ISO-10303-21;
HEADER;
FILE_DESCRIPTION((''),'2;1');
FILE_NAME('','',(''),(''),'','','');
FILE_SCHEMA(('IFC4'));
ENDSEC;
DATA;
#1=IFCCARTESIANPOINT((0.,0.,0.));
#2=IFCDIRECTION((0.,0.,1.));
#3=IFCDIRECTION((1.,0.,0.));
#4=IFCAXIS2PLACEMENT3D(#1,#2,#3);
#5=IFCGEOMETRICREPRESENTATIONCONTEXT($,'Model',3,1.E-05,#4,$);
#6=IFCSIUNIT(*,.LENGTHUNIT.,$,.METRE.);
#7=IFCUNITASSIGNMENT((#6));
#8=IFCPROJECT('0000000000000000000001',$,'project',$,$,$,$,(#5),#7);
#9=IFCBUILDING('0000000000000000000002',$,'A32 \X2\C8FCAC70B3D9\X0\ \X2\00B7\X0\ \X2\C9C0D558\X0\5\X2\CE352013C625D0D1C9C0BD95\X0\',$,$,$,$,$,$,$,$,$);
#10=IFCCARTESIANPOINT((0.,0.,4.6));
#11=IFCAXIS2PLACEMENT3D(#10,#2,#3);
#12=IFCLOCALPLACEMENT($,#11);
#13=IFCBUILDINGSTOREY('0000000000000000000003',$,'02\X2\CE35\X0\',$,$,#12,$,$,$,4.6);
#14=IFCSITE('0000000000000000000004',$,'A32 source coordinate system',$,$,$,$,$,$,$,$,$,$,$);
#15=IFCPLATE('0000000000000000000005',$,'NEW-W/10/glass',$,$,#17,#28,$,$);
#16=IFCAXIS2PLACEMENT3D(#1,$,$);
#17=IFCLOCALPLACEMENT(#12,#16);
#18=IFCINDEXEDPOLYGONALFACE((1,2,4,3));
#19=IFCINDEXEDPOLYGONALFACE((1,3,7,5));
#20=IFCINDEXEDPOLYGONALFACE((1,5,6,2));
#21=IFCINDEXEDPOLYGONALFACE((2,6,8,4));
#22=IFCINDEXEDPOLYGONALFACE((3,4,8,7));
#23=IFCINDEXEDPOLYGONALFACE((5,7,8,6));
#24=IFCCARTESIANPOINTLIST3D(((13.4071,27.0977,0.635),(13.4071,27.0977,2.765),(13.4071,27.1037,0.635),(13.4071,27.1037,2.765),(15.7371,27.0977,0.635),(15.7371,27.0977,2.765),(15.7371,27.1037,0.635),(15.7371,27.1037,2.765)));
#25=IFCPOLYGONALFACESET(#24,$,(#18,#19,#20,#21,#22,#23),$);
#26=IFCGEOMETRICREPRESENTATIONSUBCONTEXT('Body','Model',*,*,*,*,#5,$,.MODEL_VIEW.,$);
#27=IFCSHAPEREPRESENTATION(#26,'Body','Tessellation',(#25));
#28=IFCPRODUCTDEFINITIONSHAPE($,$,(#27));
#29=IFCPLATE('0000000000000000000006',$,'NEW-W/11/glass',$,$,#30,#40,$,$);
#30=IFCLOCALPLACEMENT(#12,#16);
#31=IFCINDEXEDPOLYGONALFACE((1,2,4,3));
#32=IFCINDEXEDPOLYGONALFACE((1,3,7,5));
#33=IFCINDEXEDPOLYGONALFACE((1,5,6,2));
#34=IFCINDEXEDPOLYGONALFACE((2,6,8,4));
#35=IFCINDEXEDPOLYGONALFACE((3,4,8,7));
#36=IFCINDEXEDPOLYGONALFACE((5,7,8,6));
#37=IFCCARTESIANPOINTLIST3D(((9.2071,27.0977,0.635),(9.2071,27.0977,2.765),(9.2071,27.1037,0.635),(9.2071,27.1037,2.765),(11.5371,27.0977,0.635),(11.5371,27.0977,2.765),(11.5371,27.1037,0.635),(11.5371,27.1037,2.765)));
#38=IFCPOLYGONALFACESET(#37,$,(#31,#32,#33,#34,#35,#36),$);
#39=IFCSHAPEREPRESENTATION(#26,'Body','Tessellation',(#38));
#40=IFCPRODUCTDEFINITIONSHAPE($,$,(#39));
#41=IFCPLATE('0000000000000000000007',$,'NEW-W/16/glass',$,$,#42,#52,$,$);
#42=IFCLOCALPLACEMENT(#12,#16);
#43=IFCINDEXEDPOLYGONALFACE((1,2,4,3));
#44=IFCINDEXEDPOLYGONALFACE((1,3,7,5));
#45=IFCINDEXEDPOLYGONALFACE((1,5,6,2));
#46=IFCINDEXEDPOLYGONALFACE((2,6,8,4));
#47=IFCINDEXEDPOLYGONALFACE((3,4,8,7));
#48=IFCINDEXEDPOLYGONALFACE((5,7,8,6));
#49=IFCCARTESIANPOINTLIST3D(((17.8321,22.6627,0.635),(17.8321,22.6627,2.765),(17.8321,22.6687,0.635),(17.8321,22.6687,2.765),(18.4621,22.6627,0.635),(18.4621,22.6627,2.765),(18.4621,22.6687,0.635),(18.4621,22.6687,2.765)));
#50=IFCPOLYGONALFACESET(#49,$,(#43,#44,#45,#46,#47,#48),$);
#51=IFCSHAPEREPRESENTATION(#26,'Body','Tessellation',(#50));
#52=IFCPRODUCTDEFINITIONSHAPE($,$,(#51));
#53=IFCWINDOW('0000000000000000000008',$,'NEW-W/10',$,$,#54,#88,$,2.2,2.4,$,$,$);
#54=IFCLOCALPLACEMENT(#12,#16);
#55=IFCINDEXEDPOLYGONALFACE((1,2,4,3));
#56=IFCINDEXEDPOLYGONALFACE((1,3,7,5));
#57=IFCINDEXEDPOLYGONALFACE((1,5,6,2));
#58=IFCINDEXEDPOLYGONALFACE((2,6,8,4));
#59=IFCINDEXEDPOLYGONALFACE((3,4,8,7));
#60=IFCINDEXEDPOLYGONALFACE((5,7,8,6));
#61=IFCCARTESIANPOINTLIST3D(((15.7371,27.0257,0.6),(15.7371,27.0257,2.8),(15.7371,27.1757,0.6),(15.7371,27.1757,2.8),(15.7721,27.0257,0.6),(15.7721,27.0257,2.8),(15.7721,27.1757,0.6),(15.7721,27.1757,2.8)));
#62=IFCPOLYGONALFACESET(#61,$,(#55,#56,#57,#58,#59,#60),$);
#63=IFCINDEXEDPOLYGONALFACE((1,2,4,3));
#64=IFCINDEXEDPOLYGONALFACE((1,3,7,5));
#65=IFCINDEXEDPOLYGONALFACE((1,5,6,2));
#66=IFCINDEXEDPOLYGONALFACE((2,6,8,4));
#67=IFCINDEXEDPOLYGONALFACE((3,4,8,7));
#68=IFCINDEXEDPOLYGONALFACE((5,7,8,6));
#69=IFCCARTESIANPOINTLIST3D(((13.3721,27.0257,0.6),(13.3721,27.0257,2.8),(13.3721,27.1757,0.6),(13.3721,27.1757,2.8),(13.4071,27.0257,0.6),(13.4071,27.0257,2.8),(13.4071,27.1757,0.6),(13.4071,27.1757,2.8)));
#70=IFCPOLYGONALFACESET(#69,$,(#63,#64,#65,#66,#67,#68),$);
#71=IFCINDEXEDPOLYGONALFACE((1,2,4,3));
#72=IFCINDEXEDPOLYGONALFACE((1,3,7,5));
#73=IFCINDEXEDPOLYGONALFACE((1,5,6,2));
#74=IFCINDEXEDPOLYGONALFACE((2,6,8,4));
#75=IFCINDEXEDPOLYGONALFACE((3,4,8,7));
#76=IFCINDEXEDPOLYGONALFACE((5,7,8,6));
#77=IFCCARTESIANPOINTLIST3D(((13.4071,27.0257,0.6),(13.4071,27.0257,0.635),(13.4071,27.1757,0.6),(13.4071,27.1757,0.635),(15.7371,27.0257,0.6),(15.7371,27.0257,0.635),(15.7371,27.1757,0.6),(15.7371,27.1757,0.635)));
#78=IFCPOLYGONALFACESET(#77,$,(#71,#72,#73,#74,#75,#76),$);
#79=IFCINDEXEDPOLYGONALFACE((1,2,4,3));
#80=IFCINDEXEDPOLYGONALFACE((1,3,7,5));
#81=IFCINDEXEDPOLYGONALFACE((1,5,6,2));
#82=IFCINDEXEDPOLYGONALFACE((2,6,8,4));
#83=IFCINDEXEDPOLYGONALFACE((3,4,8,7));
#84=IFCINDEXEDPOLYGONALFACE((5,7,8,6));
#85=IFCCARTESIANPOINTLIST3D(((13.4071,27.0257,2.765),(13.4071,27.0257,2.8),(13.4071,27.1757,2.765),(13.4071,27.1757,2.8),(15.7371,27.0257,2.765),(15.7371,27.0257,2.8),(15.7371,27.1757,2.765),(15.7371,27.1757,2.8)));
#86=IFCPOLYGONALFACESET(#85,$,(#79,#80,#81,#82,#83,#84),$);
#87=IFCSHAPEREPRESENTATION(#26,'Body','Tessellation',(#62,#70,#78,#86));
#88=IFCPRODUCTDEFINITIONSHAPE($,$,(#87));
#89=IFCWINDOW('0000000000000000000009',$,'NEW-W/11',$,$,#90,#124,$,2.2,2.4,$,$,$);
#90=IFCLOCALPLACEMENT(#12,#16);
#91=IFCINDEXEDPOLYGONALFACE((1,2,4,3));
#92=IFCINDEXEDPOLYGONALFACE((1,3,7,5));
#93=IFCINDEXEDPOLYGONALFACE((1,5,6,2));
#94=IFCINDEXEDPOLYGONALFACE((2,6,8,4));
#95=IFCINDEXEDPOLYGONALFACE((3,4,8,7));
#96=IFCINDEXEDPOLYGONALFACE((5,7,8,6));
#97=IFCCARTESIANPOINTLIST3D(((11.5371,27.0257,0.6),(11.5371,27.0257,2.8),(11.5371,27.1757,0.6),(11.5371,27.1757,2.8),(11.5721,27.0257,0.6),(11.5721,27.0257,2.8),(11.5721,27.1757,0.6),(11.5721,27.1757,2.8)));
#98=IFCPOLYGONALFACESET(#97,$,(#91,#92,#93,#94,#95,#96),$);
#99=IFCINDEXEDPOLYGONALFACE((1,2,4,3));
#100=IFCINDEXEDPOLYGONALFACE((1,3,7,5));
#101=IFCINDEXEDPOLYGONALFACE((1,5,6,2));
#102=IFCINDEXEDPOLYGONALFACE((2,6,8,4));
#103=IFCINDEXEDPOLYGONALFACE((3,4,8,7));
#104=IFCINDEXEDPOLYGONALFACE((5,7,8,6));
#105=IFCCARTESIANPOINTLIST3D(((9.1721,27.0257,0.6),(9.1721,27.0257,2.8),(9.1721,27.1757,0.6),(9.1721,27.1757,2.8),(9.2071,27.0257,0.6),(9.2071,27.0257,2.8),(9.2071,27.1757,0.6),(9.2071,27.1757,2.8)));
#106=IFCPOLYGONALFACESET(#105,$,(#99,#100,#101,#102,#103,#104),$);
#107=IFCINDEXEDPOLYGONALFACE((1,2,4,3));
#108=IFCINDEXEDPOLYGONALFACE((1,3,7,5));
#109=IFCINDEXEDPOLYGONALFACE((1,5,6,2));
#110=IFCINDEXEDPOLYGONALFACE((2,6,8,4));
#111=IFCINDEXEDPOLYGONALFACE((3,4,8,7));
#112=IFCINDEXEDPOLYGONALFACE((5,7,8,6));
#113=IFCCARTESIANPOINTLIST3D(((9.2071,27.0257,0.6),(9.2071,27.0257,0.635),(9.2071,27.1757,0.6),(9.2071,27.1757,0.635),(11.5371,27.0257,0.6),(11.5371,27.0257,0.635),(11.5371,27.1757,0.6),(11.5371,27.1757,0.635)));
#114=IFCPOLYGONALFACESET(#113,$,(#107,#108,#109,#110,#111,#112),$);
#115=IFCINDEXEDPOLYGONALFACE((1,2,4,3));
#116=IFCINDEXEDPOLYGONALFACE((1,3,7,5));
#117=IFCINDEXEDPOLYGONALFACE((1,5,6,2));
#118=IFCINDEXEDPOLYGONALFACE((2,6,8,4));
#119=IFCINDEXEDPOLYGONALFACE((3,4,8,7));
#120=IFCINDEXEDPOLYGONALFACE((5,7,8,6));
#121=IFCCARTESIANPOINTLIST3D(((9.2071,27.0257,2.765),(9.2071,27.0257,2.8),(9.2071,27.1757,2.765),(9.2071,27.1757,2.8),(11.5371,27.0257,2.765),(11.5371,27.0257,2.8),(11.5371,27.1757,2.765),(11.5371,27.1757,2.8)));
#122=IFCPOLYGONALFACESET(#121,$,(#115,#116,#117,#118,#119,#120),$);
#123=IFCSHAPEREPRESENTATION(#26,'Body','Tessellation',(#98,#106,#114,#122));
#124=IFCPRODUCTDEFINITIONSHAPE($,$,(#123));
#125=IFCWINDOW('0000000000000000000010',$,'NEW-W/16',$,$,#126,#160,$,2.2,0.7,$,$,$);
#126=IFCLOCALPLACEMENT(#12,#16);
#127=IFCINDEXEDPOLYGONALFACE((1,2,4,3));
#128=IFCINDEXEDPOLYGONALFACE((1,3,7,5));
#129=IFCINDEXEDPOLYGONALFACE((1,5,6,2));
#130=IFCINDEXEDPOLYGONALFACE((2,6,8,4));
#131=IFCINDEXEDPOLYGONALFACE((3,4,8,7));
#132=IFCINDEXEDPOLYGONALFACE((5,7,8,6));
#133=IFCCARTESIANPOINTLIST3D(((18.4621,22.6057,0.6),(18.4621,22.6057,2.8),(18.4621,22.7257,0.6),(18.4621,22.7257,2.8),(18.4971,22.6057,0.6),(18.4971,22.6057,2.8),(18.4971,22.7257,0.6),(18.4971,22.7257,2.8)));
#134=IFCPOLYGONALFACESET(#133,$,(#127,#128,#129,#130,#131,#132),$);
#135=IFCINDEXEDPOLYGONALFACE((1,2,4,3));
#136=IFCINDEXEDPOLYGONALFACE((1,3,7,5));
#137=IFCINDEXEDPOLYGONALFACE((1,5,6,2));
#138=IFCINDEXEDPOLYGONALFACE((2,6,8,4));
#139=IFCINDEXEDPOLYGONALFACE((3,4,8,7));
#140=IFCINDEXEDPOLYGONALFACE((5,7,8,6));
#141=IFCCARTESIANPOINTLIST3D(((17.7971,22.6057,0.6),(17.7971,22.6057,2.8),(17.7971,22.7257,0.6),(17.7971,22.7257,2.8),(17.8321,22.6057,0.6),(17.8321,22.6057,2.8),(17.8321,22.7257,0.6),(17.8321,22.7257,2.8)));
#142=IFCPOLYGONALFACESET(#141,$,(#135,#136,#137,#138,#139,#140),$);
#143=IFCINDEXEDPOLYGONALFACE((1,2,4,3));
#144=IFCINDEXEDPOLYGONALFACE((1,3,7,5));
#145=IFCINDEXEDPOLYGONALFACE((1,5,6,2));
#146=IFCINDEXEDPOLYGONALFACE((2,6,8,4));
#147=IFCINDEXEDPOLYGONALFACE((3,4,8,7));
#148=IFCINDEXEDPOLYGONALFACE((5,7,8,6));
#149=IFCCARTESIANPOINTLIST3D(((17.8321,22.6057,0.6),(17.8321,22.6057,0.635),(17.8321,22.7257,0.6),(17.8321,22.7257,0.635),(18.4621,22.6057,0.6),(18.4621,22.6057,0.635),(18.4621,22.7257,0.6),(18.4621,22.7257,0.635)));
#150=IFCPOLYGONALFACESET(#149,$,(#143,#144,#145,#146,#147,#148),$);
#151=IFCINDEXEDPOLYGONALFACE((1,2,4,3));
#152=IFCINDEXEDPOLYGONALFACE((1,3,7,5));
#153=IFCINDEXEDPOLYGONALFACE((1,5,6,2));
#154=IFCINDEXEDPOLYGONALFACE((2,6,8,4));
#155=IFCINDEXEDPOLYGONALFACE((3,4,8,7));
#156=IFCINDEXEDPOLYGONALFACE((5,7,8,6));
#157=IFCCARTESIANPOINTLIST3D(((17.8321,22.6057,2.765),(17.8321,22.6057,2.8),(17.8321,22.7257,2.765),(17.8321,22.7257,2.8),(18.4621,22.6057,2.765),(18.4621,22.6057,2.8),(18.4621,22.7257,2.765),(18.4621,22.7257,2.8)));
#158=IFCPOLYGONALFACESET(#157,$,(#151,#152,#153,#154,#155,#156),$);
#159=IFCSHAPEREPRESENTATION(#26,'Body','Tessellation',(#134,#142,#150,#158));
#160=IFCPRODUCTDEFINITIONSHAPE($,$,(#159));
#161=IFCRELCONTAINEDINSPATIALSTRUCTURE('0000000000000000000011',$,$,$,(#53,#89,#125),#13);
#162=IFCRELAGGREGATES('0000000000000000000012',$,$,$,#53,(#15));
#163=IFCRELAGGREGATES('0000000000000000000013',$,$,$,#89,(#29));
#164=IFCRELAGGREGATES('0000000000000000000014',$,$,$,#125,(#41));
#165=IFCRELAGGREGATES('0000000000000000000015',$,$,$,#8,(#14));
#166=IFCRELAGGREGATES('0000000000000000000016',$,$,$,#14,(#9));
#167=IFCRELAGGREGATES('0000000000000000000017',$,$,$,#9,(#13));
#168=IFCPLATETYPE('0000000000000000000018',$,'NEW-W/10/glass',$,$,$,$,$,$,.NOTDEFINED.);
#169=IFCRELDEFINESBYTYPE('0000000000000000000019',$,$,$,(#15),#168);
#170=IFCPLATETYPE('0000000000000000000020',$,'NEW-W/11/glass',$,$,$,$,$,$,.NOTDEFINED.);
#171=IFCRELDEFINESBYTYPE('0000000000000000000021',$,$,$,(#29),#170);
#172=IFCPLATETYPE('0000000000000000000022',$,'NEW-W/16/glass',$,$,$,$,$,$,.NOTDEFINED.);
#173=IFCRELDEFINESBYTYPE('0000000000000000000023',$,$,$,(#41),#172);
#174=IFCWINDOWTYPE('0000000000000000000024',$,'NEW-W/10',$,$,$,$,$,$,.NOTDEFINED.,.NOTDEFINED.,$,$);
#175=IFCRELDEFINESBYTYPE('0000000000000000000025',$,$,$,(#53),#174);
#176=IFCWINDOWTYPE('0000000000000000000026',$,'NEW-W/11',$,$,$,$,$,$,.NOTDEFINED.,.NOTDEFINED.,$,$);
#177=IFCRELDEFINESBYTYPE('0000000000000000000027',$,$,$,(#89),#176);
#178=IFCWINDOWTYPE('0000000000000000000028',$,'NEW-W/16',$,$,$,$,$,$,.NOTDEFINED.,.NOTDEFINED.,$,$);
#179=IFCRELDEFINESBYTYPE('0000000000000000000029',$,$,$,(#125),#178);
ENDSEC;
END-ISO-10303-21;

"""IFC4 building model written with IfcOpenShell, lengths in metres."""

from ifc_helpers import new_model, si_unit, frame, origin, origin_with_axes, place, context, subcontext, project, spatial, polyline, outline, extrude, source, transform, mapped, type_object, type_shapes, element, aggregate, save


model = new_model("IFC4")

# Units and contexts
model_context = context("Model", 3, precision=1e-05, world=origin_with_axes())
body_context = subcontext(model_context, "Body", "Model", "MODEL_VIEW")
ifc_project = project(units=[si_unit("LENGTHUNIT", "METRE")], contexts=[model_context])

# Plates
storey_placement = place(None, frame((0.0, 0.0, 4.6), z_axis=(0.0, 0.0, 1.0), x_axis=(1.0, 0.0, 0.0)))
plate_type_1 = type_object("IfcPlateType", Name="NEW-W/10/glass", PredefinedType="NOTDEFINED")
shared_shape_1 = source(origin(), body_context, "Body", "SweptSolid", [
    extrude(outline(polyline([(15.7371, 27.0977), (13.4071, 27.0977), (13.4071, 27.1037), (15.7371, 27.1037), (15.7371, 27.0977)])), frame((0.0, 0.0, 0.635)), (0.0, 0.0, 1.0), 2.13),
])
type_shapes(plate_type_1, [shared_shape_1])
window_1_placement = place(storey_placement, origin_with_axes())
plate_1_placement = place(window_1_placement, origin_with_axes())
plate_1 = element("IfcPlate", 1, at=plate_1_placement, type_object=plate_type_1, Name="NEW-W/10/glass", context=body_context, shape_type="MappedRepresentation", body=[
    mapped(shared_shape_1, transform((0.0, 0.0, 0.0), scale=1.0)),
])
plate_type_2 = type_object("IfcPlateType", Name="NEW-W/11/glass", PredefinedType="NOTDEFINED")
shared_shape_2 = source(origin(), body_context, "Body", "SweptSolid", [
    extrude(outline(polyline([(11.5371, 27.0977), (9.2071, 27.0977), (9.2071, 27.1037), (11.5371, 27.1037), (11.5371, 27.0977)])), frame((0.0, 0.0, 0.635)), (0.0, 0.0, 1.0), 2.13),
])
type_shapes(plate_type_2, [shared_shape_2])
window_2_placement = place(storey_placement, origin_with_axes())
plate_2_placement = place(window_2_placement, origin_with_axes())
plate_2 = element("IfcPlate", 2, at=plate_2_placement, type_object=plate_type_2, Name="NEW-W/11/glass", context=body_context, shape_type="MappedRepresentation", body=[
    mapped(shared_shape_2, transform((0.0, 0.0, 0.0), scale=1.0)),
])
plate_type_3 = type_object("IfcPlateType", Name="NEW-W/16/glass", PredefinedType="NOTDEFINED")
shared_shape_3 = source(origin(), body_context, "Body", "SweptSolid", [
    extrude(outline(polyline([(18.4621, 22.6627), (17.8321, 22.6627), (17.8321, 22.6687), (18.4621, 22.6687), (18.4621, 22.6627)])), frame((0.0, 0.0, 0.635)), (0.0, 0.0, 1.0), 2.13),
])
type_shapes(plate_type_3, [shared_shape_3])
window_3_placement = place(storey_placement, origin_with_axes())
plate_3_placement = place(window_3_placement, origin_with_axes())
plate_3 = element("IfcPlate", 3, at=plate_3_placement, type_object=plate_type_3, Name="NEW-W/16/glass", context=body_context, shape_type="MappedRepresentation", body=[
    mapped(shared_shape_3, transform((0.0, 0.0, 0.0), scale=1.0)),
])

# Site, building, storey
site = spatial("IfcSite", under=ifc_project, Name="A32 source coordinate system")
building = spatial("IfcBuilding", under=site, Name="A32 주거동 · 지하5층–옥탑지붕")
storey = spatial("IfcBuildingStorey", under=building, at=storey_placement, Name="02층", Elevation=4.6)

# Windows
window_type_1 = type_object("IfcWindowType", Name="NEW-W/10", PartitioningType="NOTDEFINED", PredefinedType="NOTDEFINED")
shared_shape_4 = source(origin(), body_context, "Body", "SweptSolid", [
    extrude(outline(polyline([(15.7371, 27.0257), (15.7371, 27.1757), (15.7721, 27.1757), (15.7721, 27.0257), (15.7371, 27.0257)])), frame((0.0, 0.0, 0.6)), (0.0, 0.0, 1.0), 2.2),
    extrude(outline(polyline([(13.3721, 27.0257), (13.3721, 27.1757), (13.4071, 27.1757), (13.4071, 27.0257), (13.3721, 27.0257)])), frame((0.0, 0.0, 0.6)), (0.0, 0.0, 1.0), 2.2),
    extrude(outline(polyline([(15.7371, 27.0257), (15.7371, 27.1757), (13.4071, 27.1757), (13.4071, 27.0257), (15.7371, 27.0257)])), frame((0.0, 0.0, 0.6)), (0.0, 0.0, 1.0), 0.035),
    extrude(outline(polyline([(15.7371, 27.0257), (15.7371, 27.1757), (13.4071, 27.1757), (13.4071, 27.0257), (15.7371, 27.0257)])), frame((0.0, 0.0, 2.765)), (0.0, 0.0, 1.0), 0.035),
])
type_shapes(window_type_1, [shared_shape_4])
window_1 = element("IfcWindow", 4, at=window_1_placement, inside=storey, type_object=window_type_1, Name="NEW-W/10", OverallHeight=2.2, OverallWidth=2.4, context=body_context, shape_type="MappedRepresentation", body=[
    mapped(shared_shape_4, transform((0.0, 0.0, 0.0), scale=1.0)),
])
aggregate(window_1, [plate_1])
window_type_2 = type_object("IfcWindowType", Name="NEW-W/11", PartitioningType="NOTDEFINED", PredefinedType="NOTDEFINED")
shared_shape_5 = source(origin(), body_context, "Body", "SweptSolid", [
    extrude(outline(polyline([(11.5371, 27.0257), (11.5371, 27.1757), (11.5721, 27.1757), (11.5721, 27.0257), (11.5371, 27.0257)])), frame((0.0, 0.0, 0.6)), (0.0, 0.0, 1.0), 2.2),
    extrude(outline(polyline([(9.1721, 27.0257), (9.1721, 27.1757), (9.2071, 27.1757), (9.2071, 27.0257), (9.1721, 27.0257)])), frame((0.0, 0.0, 0.6)), (0.0, 0.0, 1.0), 2.2),
    extrude(outline(polyline([(11.5371, 27.0257), (11.5371, 27.1757), (9.2071, 27.1757), (9.2071, 27.0257), (11.5371, 27.0257)])), frame((0.0, 0.0, 0.6)), (0.0, 0.0, 1.0), 0.035),
    extrude(outline(polyline([(11.5371, 27.0257), (11.5371, 27.1757), (9.2071, 27.1757), (9.2071, 27.0257), (11.5371, 27.0257)])), frame((0.0, 0.0, 2.765)), (0.0, 0.0, 1.0), 0.035),
])
type_shapes(window_type_2, [shared_shape_5])
window_2 = element("IfcWindow", 5, at=window_2_placement, inside=storey, type_object=window_type_2, Name="NEW-W/11", OverallHeight=2.2, OverallWidth=2.4, context=body_context, shape_type="MappedRepresentation", body=[
    mapped(shared_shape_5, transform((0.0, 0.0, 0.0), scale=1.0)),
])
aggregate(window_2, [plate_2])
window_type_3 = type_object("IfcWindowType", Name="NEW-W/16", PartitioningType="NOTDEFINED", PredefinedType="NOTDEFINED")
shared_shape_6 = source(origin(), body_context, "Body", "SweptSolid", [
    extrude(outline(polyline([(18.4621, 22.6057), (18.4621, 22.7257), (18.4971, 22.7257), (18.4971, 22.6057), (18.4621, 22.6057)])), frame((0.0, 0.0, 0.6)), (0.0, 0.0, 1.0), 2.2),
    extrude(outline(polyline([(17.7971, 22.6057), (17.7971, 22.7257), (17.8321, 22.7257), (17.8321, 22.6057), (17.7971, 22.6057)])), frame((0.0, 0.0, 0.6)), (0.0, 0.0, 1.0), 2.2),
    extrude(outline(polyline([(18.4621, 22.6057), (18.4621, 22.7257), (17.8321, 22.7257), (17.8321, 22.6057), (18.4621, 22.6057)])), frame((0.0, 0.0, 0.6)), (0.0, 0.0, 1.0), 0.035),
    extrude(outline(polyline([(18.4621, 22.6057), (18.4621, 22.7257), (17.8321, 22.7257), (17.8321, 22.6057), (18.4621, 22.6057)])), frame((0.0, 0.0, 2.765)), (0.0, 0.0, 1.0), 0.035),
])
type_shapes(window_type_3, [shared_shape_6])
window_3 = element("IfcWindow", 6, at=window_3_placement, inside=storey, type_object=window_type_3, Name="NEW-W/16", OverallHeight=2.2, OverallWidth=0.7, context=body_context, shape_type="MappedRepresentation", body=[
    mapped(shared_shape_6, transform((0.0, 0.0, 0.0), scale=1.0)),
])
aggregate(window_3, [plate_3])

save(model, "model.ifc")
